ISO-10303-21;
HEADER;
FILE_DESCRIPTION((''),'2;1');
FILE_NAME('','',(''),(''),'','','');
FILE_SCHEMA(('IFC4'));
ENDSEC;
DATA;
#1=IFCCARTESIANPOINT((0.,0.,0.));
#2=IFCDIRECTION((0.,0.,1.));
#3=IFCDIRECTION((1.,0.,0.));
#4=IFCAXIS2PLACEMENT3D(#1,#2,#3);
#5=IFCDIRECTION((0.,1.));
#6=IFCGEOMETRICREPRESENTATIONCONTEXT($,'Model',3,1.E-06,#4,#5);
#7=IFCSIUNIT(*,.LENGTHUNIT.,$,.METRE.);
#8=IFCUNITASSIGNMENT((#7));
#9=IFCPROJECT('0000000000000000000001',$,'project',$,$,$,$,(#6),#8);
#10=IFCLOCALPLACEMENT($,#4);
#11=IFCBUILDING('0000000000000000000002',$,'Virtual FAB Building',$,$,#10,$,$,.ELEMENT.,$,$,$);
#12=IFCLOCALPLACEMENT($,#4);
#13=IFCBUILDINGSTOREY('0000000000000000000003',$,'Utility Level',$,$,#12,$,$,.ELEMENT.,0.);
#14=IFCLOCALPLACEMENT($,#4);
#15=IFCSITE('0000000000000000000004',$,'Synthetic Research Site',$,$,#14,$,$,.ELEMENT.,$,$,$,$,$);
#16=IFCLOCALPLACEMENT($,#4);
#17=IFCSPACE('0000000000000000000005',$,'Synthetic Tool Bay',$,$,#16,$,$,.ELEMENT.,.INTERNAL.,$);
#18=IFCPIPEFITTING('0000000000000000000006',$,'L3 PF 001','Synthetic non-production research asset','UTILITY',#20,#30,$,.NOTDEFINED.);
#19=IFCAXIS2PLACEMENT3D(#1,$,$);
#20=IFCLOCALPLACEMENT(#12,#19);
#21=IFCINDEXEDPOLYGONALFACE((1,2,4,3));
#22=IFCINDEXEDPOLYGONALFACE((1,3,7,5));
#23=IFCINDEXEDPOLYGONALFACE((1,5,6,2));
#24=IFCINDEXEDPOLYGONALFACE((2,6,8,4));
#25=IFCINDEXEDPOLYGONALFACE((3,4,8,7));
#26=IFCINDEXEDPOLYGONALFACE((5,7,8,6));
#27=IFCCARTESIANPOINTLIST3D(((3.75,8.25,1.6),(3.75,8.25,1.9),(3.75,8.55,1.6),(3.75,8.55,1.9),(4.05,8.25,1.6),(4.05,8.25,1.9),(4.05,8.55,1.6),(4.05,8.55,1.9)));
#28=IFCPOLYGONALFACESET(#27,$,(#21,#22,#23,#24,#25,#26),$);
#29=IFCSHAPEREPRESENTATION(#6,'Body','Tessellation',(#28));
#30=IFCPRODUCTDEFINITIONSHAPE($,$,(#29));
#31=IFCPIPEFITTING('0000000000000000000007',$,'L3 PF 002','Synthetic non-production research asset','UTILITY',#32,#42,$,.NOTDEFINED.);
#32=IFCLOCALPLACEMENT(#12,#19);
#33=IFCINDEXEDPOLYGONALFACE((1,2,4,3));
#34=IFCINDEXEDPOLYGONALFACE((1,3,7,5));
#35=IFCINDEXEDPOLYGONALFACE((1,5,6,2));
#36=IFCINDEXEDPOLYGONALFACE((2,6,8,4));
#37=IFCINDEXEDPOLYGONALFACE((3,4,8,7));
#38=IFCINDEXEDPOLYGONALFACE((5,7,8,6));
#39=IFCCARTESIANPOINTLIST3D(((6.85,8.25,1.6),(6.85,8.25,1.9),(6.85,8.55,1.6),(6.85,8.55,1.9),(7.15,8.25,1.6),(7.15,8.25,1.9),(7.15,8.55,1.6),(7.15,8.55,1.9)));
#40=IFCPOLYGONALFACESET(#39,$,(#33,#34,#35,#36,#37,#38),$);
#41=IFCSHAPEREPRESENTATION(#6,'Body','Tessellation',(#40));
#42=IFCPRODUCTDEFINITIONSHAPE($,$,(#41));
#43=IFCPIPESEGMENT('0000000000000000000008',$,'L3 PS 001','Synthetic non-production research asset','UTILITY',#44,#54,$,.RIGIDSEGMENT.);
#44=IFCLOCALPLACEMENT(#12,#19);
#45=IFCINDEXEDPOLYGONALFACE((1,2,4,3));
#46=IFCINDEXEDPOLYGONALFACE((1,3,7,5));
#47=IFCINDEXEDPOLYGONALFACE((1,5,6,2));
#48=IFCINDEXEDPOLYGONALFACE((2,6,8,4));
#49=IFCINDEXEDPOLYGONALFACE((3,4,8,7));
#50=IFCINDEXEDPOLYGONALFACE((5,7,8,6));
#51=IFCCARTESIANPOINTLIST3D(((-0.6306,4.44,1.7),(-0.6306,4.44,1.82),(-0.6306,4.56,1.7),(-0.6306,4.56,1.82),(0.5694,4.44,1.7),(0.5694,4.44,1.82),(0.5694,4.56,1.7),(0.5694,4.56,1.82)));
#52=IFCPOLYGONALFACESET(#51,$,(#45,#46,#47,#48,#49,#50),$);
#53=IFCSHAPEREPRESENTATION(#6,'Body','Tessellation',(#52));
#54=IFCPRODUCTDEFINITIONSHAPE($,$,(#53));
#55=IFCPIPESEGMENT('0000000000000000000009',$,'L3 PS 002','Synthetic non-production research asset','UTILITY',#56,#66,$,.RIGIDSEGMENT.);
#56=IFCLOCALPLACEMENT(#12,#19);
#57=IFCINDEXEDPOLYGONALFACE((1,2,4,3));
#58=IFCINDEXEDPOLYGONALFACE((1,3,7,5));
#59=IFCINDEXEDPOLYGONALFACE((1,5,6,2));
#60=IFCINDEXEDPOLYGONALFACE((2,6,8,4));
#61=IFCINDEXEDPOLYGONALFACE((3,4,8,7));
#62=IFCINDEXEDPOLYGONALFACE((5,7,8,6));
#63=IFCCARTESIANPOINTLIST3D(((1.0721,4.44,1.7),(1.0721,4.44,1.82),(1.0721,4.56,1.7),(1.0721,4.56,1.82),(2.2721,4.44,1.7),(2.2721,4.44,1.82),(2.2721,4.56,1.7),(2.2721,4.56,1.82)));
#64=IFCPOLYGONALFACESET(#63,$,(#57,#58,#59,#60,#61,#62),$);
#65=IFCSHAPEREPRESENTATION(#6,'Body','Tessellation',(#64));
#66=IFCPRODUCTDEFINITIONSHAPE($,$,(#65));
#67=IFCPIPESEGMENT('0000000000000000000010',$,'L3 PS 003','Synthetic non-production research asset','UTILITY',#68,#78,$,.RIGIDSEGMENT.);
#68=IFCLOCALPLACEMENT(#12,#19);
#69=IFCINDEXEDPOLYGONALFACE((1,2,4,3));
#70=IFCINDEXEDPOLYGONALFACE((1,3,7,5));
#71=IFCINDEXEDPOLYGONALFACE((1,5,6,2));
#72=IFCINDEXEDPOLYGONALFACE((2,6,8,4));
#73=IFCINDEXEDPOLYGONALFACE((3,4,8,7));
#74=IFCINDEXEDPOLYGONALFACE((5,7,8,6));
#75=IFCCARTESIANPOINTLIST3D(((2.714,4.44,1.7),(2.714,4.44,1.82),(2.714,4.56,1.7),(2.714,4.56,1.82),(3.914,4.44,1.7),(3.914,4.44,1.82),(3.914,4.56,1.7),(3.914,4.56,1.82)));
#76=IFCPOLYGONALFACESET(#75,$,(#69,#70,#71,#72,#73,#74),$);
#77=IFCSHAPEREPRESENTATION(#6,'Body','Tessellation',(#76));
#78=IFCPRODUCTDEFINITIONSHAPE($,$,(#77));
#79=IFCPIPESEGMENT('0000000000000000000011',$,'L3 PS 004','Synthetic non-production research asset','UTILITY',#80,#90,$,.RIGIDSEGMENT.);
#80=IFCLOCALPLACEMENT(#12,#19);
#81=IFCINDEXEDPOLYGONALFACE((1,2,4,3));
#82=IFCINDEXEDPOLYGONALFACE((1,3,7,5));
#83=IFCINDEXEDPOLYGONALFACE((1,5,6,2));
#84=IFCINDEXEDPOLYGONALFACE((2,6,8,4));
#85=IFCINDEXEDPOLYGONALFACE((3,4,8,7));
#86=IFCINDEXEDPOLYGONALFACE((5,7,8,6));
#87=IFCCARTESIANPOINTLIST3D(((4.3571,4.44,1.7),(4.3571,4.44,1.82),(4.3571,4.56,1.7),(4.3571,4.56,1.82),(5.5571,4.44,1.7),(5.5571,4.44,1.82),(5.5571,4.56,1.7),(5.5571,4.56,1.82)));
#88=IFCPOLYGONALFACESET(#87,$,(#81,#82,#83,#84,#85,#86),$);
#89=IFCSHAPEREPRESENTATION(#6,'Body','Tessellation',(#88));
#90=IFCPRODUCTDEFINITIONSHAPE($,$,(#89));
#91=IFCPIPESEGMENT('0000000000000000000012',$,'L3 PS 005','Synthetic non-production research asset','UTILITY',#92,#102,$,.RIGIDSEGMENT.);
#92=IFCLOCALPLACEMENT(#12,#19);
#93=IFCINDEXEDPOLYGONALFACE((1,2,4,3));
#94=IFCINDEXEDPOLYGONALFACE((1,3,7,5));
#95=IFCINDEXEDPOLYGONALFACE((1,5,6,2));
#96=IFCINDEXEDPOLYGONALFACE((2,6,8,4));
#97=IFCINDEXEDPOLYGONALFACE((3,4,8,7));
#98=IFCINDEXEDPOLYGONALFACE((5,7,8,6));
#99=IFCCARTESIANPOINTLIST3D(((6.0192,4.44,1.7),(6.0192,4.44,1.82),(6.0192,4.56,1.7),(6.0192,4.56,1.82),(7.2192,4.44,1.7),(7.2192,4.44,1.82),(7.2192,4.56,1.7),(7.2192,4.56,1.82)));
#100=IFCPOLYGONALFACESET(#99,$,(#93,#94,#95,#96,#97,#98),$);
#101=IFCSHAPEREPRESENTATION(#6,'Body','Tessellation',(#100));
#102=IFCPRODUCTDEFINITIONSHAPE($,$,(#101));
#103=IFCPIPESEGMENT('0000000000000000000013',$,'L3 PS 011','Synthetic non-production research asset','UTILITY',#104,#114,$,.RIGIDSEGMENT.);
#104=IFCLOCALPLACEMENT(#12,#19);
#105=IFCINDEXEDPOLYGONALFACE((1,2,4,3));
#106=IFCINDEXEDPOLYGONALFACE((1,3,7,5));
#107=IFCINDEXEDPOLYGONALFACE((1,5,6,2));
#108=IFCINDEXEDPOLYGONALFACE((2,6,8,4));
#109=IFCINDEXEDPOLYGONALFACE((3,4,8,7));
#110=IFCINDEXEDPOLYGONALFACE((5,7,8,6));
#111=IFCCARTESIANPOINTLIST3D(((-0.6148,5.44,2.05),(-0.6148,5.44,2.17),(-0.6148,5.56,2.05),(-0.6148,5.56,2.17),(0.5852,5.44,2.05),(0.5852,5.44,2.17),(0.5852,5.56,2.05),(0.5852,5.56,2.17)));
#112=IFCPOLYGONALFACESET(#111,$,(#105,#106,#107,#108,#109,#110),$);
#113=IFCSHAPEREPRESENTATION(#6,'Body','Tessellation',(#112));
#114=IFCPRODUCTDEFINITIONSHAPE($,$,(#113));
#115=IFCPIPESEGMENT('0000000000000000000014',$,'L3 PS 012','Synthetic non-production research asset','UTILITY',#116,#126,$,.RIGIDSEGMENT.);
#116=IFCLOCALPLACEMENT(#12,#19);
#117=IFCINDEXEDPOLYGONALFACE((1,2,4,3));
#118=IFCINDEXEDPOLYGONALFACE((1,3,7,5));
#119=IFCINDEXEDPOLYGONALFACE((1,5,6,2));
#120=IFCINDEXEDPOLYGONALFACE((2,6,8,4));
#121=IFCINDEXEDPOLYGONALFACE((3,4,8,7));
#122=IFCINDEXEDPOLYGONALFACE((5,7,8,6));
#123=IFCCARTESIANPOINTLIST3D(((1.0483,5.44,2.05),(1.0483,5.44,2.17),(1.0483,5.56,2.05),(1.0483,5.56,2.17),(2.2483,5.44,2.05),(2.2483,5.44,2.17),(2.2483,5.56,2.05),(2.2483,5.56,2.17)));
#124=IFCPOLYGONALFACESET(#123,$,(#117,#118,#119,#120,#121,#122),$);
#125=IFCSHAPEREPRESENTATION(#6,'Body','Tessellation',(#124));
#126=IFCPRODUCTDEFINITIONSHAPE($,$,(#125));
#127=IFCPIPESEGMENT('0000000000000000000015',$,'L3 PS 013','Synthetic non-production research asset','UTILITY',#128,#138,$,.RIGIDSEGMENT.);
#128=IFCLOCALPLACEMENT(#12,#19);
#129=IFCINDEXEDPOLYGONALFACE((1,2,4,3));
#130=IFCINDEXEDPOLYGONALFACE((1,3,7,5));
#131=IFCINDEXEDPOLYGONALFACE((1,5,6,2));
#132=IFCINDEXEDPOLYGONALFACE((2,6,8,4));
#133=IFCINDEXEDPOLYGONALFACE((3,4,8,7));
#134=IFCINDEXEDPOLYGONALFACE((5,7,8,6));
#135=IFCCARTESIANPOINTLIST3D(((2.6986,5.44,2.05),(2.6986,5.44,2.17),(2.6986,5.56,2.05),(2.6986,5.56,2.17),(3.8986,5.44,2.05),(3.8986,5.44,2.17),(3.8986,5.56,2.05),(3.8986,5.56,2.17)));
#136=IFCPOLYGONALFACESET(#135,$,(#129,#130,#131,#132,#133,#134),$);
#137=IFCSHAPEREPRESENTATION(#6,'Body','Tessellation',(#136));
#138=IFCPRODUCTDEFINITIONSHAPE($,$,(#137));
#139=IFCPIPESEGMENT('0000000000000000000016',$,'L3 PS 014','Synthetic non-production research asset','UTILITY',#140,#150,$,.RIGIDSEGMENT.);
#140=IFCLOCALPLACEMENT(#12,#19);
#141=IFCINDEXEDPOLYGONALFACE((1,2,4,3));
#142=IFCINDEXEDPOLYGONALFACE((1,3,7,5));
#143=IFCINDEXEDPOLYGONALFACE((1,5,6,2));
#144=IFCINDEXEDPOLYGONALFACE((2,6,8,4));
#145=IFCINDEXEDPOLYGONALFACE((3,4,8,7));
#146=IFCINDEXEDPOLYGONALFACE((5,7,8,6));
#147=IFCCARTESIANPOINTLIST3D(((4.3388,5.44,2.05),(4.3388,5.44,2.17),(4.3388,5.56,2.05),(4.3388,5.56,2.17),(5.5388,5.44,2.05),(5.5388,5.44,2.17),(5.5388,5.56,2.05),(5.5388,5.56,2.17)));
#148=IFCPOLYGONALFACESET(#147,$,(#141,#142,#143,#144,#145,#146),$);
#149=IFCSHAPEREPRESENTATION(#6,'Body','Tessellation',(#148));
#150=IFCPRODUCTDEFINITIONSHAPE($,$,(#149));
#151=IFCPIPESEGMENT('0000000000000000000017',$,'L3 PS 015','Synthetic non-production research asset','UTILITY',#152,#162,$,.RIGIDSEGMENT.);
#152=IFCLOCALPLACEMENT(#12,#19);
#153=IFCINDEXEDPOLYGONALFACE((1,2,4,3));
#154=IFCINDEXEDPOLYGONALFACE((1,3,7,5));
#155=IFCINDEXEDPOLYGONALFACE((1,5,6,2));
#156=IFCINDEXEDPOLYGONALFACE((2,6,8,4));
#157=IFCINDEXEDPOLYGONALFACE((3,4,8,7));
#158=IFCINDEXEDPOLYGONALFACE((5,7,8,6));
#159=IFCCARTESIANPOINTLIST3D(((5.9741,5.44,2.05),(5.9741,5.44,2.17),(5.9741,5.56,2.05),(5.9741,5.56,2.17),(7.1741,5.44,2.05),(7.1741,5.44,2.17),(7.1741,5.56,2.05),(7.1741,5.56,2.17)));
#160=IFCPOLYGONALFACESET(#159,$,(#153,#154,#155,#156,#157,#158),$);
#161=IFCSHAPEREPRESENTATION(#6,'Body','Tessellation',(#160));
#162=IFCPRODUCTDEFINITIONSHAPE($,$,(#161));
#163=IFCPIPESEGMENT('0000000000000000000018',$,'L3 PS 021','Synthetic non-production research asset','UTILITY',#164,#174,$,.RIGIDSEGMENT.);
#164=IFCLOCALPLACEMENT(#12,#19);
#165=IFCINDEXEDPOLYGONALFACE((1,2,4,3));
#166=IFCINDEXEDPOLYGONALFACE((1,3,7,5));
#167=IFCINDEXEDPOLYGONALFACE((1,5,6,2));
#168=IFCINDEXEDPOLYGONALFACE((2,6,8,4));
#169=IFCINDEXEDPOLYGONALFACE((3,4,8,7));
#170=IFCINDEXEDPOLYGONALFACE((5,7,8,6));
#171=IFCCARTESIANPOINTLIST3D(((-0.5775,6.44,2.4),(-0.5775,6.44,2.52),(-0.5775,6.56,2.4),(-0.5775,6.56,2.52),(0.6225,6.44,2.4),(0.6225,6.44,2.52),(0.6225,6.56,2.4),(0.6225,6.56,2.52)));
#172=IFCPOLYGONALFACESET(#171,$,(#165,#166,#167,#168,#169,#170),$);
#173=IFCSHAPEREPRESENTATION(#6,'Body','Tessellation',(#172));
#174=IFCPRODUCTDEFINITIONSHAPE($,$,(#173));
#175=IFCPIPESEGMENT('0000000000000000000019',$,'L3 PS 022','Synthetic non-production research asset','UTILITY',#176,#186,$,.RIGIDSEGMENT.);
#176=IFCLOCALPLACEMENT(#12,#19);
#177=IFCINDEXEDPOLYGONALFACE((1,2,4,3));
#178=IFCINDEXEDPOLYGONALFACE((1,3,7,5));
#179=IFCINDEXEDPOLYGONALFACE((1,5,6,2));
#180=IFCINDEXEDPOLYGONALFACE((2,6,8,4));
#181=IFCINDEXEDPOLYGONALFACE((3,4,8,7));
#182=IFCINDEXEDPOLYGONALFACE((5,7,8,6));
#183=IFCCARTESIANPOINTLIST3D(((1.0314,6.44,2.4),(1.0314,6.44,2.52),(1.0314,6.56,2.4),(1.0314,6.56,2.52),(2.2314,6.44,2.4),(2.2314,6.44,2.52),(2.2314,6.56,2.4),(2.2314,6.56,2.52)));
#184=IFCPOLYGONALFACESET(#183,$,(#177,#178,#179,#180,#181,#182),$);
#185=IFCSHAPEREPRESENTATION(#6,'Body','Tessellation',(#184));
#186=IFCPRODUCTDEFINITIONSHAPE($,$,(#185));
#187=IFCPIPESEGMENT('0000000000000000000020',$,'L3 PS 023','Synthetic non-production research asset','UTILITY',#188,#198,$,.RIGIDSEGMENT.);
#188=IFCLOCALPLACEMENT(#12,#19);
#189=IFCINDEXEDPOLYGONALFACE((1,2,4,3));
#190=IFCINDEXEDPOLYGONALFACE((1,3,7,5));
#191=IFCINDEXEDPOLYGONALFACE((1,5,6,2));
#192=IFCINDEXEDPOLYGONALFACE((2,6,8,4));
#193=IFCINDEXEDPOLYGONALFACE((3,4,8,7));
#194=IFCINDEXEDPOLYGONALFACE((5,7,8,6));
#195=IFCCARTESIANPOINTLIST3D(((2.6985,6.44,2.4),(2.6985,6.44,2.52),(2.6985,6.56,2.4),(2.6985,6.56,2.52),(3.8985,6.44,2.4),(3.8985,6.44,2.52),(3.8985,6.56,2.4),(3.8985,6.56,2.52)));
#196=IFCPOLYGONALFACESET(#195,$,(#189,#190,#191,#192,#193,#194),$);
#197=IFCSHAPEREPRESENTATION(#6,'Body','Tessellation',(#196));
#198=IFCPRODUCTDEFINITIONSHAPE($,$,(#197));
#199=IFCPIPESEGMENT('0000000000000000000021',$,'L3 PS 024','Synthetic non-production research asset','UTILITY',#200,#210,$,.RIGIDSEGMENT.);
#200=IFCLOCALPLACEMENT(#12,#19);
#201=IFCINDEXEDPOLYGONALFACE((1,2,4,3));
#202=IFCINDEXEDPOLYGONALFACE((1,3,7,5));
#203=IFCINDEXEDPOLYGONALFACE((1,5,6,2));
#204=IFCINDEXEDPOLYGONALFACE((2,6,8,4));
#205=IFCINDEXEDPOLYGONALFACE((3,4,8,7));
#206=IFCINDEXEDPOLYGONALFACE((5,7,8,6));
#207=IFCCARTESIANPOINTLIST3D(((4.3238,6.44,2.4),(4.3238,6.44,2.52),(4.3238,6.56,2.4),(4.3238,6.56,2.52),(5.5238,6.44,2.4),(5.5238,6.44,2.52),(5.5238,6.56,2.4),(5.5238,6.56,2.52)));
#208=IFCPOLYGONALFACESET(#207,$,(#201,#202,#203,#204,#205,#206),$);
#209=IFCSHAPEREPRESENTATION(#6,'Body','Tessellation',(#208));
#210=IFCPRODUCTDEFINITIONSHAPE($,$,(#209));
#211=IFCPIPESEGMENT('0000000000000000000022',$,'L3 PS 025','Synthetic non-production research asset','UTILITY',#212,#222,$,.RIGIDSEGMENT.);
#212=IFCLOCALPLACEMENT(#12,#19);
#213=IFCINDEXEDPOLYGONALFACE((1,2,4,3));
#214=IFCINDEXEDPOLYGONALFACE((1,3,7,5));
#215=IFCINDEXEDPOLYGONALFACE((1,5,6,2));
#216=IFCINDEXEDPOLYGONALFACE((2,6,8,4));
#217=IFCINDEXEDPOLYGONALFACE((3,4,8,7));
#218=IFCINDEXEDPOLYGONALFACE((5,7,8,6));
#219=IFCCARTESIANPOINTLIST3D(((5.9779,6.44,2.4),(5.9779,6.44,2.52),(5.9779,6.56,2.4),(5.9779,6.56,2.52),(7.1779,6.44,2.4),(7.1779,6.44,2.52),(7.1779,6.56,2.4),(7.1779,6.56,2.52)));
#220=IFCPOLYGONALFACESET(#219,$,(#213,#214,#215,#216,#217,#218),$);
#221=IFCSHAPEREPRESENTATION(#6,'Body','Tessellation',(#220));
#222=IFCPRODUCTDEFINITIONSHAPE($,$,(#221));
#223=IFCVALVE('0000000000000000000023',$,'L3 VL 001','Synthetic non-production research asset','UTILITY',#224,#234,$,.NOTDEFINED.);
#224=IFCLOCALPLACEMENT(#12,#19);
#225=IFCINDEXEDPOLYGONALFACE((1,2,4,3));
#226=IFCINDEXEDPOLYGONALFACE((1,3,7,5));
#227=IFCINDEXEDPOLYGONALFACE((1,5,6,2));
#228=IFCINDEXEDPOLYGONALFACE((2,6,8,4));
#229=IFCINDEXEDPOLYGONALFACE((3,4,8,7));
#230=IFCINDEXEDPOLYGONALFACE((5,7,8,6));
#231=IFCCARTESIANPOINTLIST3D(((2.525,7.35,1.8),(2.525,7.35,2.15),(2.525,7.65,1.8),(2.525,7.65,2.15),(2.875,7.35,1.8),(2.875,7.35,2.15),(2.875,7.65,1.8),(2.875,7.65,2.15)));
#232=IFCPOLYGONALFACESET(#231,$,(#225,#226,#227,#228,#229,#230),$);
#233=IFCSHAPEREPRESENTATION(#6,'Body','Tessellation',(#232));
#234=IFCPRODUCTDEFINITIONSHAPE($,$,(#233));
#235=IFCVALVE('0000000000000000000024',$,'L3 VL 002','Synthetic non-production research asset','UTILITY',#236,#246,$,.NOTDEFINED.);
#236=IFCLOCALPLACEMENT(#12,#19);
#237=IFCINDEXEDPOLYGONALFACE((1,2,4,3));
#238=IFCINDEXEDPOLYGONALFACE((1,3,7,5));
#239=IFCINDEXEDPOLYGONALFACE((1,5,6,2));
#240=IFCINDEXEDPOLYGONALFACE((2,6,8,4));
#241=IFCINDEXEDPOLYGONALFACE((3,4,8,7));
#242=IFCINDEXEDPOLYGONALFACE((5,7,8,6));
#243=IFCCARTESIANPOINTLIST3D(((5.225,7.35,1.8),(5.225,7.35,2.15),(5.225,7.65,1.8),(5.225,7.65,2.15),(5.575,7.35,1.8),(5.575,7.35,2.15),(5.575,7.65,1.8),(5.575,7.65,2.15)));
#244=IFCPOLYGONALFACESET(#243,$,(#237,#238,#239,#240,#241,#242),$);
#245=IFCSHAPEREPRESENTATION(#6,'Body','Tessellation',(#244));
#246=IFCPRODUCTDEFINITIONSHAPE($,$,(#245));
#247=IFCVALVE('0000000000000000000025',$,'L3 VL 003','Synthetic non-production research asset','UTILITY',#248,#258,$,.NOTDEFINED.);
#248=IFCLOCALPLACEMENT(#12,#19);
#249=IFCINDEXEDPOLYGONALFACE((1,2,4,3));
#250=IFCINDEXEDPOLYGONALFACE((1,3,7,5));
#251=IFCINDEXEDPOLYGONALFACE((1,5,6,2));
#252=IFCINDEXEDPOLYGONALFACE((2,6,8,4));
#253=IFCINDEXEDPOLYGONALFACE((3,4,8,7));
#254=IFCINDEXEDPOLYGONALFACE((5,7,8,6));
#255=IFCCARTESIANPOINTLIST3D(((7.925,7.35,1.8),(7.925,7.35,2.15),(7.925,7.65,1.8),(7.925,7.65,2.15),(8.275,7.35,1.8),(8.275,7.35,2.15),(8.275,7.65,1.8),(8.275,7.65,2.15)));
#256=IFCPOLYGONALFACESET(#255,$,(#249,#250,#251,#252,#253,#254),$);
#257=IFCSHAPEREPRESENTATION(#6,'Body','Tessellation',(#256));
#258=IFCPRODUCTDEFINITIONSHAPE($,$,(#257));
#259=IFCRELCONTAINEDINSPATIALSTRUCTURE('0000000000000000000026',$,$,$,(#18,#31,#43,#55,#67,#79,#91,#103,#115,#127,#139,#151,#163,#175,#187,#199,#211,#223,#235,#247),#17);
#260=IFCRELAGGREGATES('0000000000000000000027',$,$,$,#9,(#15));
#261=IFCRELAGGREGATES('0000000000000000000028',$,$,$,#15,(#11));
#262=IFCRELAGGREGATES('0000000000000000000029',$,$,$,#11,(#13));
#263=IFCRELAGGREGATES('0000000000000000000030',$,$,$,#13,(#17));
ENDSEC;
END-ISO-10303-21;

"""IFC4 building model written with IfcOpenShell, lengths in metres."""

from ifc_helpers import new_model, si_unit, direction, frame, origin_with_axes, origin_2d_with_axis, place, context, project, spatial, rectangle, extrude, element, save


model = new_model("IFC4")

# Units and contexts
model_context = context("Model", 3, precision=1e-06, world=origin_with_axes(), true_north=direction((0.0, 1.0)))
ifc_project = project(units=[si_unit("LENGTHUNIT", "METRE")], contexts=[model_context])

# Site, building, storey, space
site_placement = place(None, origin_with_axes())
site = spatial("IfcSite", under=ifc_project, at=site_placement, Name="Synthetic Research Site", CompositionType="ELEMENT")
building_placement = place(None, origin_with_axes())
building = spatial("IfcBuilding", under=site, at=building_placement, Name="Virtual FAB Building", CompositionType="ELEMENT")
storey_placement = place(None, origin_with_axes())
storey = spatial("IfcBuildingStorey", under=building, at=storey_placement, Name="Utility Level", CompositionType="ELEMENT", Elevation=0.0)
space_placement = place(None, origin_with_axes())
space = spatial("IfcSpace", under=storey, at=space_placement, Name="Synthetic Tool Bay", CompositionType="ELEMENT", PredefinedType="INTERNAL")

# Pipe fittings
for number, where, z_axis, x_axis, name in (
    (1, (3.9, 8.4, 1.6), (0.0, 0.0, 1.0), (1.0, 0.0, 0.0), "L3 PF 001"),
    (2, (7.0, 8.4, 1.6), (0.0, 0.0, 1.0), (1.0, 0.0, 0.0), "L3 PF 002"),
):
    element("IfcPipeFitting", number, at=place(None, frame(where, z_axis=z_axis, x_axis=x_axis)), inside=space, Name=name, Description="Synthetic non-production research asset", ObjectType="UTILITY", PredefinedType="NOTDEFINED", context=model_context, shape_type="SweptSolid", body=[
        extrude(rectangle(XDim=0.3, YDim=0.3, at=origin_2d_with_axis()), origin_with_axes(), (0.0, 0.0, 1.0), 0.3),
    ])

# Pipe segments
for number, where, z_axis, x_axis, name in (
    (3, (-0.0306, 4.5, 1.7), (0.0, 0.0, 1.0), (1.0, 0.0, 0.0), "L3 PS 001"),
    (4, (1.6721, 4.5, 1.7), (0.0, 0.0, 1.0), (1.0, 0.0, 0.0), "L3 PS 002"),
    (5, (3.314, 4.5, 1.7), (0.0, 0.0, 1.0), (1.0, 0.0, 0.0), "L3 PS 003"),
    (6, (4.9571, 4.5, 1.7), (0.0, 0.0, 1.0), (1.0, 0.0, 0.0), "L3 PS 004"),
    (7, (6.6192, 4.5, 1.7), (0.0, 0.0, 1.0), (1.0, 0.0, 0.0), "L3 PS 005"),
    (8, (-0.0148, 5.5, 2.05), (0.0, 0.0, 1.0), (1.0, 0.0, 0.0), "L3 PS 011"),
    (9, (1.6483, 5.5, 2.05), (0.0, 0.0, 1.0), (1.0, 0.0, 0.0), "L3 PS 012"),
    (10, (3.2986, 5.5, 2.05), (0.0, 0.0, 1.0), (1.0, 0.0, 0.0), "L3 PS 013"),
    (11, (4.9388, 5.5, 2.05), (0.0, 0.0, 1.0), (1.0, 0.0, 0.0), "L3 PS 014"),
    (12, (6.5741, 5.5, 2.05), (0.0, 0.0, 1.0), (1.0, 0.0, 0.0), "L3 PS 015"),
    (13, (0.0225, 6.5, 2.4), (0.0, 0.0, 1.0), (1.0, 0.0, 0.0), "L3 PS 021"),
    (14, (1.6314, 6.5, 2.4), (0.0, 0.0, 1.0), (1.0, 0.0, 0.0), "L3 PS 022"),
    (15, (3.2985, 6.5, 2.4), (0.0, 0.0, 1.0), (1.0, 0.0, 0.0), "L3 PS 023"),
    (16, (4.9238, 6.5, 2.4), (0.0, 0.0, 1.0), (1.0, 0.0, 0.0), "L3 PS 024"),
    (17, (6.5779, 6.5, 2.4), (0.0, 0.0, 1.0), (1.0, 0.0, 0.0), "L3 PS 025"),
):
    element("IfcPipeSegment", number, at=place(None, frame(where, z_axis=z_axis, x_axis=x_axis)), inside=space, Name=name, Description="Synthetic non-production research asset", ObjectType="UTILITY", PredefinedType="RIGIDSEGMENT", context=model_context, shape_type="SweptSolid", body=[
        extrude(rectangle(XDim=1.2, YDim=0.12, at=origin_2d_with_axis()), origin_with_axes(), (0.0, 0.0, 1.0), 0.12),
    ])

# Valves
for number, where, z_axis, x_axis, name in (
    (18, (2.7, 7.5, 1.8), (0.0, 0.0, 1.0), (1.0, 0.0, 0.0), "L3 VL 001"),
    (19, (5.4, 7.5, 1.8), (0.0, 0.0, 1.0), (1.0, 0.0, 0.0), "L3 VL 002"),
    (20, (8.1, 7.5, 1.8), (0.0, 0.0, 1.0), (1.0, 0.0, 0.0), "L3 VL 003"),
):
    element("IfcValve", number, at=place(None, frame(where, z_axis=z_axis, x_axis=x_axis)), inside=space, Name=name, Description="Synthetic non-production research asset", ObjectType="UTILITY", PredefinedType="NOTDEFINED", context=model_context, shape_type="SweptSolid", body=[
        extrude(rectangle(XDim=0.35, YDim=0.3, at=origin_2d_with_axis()), origin_with_axes(), (0.0, 0.0, 1.0), 0.35),
    ])

save(model, "model.ifc")
